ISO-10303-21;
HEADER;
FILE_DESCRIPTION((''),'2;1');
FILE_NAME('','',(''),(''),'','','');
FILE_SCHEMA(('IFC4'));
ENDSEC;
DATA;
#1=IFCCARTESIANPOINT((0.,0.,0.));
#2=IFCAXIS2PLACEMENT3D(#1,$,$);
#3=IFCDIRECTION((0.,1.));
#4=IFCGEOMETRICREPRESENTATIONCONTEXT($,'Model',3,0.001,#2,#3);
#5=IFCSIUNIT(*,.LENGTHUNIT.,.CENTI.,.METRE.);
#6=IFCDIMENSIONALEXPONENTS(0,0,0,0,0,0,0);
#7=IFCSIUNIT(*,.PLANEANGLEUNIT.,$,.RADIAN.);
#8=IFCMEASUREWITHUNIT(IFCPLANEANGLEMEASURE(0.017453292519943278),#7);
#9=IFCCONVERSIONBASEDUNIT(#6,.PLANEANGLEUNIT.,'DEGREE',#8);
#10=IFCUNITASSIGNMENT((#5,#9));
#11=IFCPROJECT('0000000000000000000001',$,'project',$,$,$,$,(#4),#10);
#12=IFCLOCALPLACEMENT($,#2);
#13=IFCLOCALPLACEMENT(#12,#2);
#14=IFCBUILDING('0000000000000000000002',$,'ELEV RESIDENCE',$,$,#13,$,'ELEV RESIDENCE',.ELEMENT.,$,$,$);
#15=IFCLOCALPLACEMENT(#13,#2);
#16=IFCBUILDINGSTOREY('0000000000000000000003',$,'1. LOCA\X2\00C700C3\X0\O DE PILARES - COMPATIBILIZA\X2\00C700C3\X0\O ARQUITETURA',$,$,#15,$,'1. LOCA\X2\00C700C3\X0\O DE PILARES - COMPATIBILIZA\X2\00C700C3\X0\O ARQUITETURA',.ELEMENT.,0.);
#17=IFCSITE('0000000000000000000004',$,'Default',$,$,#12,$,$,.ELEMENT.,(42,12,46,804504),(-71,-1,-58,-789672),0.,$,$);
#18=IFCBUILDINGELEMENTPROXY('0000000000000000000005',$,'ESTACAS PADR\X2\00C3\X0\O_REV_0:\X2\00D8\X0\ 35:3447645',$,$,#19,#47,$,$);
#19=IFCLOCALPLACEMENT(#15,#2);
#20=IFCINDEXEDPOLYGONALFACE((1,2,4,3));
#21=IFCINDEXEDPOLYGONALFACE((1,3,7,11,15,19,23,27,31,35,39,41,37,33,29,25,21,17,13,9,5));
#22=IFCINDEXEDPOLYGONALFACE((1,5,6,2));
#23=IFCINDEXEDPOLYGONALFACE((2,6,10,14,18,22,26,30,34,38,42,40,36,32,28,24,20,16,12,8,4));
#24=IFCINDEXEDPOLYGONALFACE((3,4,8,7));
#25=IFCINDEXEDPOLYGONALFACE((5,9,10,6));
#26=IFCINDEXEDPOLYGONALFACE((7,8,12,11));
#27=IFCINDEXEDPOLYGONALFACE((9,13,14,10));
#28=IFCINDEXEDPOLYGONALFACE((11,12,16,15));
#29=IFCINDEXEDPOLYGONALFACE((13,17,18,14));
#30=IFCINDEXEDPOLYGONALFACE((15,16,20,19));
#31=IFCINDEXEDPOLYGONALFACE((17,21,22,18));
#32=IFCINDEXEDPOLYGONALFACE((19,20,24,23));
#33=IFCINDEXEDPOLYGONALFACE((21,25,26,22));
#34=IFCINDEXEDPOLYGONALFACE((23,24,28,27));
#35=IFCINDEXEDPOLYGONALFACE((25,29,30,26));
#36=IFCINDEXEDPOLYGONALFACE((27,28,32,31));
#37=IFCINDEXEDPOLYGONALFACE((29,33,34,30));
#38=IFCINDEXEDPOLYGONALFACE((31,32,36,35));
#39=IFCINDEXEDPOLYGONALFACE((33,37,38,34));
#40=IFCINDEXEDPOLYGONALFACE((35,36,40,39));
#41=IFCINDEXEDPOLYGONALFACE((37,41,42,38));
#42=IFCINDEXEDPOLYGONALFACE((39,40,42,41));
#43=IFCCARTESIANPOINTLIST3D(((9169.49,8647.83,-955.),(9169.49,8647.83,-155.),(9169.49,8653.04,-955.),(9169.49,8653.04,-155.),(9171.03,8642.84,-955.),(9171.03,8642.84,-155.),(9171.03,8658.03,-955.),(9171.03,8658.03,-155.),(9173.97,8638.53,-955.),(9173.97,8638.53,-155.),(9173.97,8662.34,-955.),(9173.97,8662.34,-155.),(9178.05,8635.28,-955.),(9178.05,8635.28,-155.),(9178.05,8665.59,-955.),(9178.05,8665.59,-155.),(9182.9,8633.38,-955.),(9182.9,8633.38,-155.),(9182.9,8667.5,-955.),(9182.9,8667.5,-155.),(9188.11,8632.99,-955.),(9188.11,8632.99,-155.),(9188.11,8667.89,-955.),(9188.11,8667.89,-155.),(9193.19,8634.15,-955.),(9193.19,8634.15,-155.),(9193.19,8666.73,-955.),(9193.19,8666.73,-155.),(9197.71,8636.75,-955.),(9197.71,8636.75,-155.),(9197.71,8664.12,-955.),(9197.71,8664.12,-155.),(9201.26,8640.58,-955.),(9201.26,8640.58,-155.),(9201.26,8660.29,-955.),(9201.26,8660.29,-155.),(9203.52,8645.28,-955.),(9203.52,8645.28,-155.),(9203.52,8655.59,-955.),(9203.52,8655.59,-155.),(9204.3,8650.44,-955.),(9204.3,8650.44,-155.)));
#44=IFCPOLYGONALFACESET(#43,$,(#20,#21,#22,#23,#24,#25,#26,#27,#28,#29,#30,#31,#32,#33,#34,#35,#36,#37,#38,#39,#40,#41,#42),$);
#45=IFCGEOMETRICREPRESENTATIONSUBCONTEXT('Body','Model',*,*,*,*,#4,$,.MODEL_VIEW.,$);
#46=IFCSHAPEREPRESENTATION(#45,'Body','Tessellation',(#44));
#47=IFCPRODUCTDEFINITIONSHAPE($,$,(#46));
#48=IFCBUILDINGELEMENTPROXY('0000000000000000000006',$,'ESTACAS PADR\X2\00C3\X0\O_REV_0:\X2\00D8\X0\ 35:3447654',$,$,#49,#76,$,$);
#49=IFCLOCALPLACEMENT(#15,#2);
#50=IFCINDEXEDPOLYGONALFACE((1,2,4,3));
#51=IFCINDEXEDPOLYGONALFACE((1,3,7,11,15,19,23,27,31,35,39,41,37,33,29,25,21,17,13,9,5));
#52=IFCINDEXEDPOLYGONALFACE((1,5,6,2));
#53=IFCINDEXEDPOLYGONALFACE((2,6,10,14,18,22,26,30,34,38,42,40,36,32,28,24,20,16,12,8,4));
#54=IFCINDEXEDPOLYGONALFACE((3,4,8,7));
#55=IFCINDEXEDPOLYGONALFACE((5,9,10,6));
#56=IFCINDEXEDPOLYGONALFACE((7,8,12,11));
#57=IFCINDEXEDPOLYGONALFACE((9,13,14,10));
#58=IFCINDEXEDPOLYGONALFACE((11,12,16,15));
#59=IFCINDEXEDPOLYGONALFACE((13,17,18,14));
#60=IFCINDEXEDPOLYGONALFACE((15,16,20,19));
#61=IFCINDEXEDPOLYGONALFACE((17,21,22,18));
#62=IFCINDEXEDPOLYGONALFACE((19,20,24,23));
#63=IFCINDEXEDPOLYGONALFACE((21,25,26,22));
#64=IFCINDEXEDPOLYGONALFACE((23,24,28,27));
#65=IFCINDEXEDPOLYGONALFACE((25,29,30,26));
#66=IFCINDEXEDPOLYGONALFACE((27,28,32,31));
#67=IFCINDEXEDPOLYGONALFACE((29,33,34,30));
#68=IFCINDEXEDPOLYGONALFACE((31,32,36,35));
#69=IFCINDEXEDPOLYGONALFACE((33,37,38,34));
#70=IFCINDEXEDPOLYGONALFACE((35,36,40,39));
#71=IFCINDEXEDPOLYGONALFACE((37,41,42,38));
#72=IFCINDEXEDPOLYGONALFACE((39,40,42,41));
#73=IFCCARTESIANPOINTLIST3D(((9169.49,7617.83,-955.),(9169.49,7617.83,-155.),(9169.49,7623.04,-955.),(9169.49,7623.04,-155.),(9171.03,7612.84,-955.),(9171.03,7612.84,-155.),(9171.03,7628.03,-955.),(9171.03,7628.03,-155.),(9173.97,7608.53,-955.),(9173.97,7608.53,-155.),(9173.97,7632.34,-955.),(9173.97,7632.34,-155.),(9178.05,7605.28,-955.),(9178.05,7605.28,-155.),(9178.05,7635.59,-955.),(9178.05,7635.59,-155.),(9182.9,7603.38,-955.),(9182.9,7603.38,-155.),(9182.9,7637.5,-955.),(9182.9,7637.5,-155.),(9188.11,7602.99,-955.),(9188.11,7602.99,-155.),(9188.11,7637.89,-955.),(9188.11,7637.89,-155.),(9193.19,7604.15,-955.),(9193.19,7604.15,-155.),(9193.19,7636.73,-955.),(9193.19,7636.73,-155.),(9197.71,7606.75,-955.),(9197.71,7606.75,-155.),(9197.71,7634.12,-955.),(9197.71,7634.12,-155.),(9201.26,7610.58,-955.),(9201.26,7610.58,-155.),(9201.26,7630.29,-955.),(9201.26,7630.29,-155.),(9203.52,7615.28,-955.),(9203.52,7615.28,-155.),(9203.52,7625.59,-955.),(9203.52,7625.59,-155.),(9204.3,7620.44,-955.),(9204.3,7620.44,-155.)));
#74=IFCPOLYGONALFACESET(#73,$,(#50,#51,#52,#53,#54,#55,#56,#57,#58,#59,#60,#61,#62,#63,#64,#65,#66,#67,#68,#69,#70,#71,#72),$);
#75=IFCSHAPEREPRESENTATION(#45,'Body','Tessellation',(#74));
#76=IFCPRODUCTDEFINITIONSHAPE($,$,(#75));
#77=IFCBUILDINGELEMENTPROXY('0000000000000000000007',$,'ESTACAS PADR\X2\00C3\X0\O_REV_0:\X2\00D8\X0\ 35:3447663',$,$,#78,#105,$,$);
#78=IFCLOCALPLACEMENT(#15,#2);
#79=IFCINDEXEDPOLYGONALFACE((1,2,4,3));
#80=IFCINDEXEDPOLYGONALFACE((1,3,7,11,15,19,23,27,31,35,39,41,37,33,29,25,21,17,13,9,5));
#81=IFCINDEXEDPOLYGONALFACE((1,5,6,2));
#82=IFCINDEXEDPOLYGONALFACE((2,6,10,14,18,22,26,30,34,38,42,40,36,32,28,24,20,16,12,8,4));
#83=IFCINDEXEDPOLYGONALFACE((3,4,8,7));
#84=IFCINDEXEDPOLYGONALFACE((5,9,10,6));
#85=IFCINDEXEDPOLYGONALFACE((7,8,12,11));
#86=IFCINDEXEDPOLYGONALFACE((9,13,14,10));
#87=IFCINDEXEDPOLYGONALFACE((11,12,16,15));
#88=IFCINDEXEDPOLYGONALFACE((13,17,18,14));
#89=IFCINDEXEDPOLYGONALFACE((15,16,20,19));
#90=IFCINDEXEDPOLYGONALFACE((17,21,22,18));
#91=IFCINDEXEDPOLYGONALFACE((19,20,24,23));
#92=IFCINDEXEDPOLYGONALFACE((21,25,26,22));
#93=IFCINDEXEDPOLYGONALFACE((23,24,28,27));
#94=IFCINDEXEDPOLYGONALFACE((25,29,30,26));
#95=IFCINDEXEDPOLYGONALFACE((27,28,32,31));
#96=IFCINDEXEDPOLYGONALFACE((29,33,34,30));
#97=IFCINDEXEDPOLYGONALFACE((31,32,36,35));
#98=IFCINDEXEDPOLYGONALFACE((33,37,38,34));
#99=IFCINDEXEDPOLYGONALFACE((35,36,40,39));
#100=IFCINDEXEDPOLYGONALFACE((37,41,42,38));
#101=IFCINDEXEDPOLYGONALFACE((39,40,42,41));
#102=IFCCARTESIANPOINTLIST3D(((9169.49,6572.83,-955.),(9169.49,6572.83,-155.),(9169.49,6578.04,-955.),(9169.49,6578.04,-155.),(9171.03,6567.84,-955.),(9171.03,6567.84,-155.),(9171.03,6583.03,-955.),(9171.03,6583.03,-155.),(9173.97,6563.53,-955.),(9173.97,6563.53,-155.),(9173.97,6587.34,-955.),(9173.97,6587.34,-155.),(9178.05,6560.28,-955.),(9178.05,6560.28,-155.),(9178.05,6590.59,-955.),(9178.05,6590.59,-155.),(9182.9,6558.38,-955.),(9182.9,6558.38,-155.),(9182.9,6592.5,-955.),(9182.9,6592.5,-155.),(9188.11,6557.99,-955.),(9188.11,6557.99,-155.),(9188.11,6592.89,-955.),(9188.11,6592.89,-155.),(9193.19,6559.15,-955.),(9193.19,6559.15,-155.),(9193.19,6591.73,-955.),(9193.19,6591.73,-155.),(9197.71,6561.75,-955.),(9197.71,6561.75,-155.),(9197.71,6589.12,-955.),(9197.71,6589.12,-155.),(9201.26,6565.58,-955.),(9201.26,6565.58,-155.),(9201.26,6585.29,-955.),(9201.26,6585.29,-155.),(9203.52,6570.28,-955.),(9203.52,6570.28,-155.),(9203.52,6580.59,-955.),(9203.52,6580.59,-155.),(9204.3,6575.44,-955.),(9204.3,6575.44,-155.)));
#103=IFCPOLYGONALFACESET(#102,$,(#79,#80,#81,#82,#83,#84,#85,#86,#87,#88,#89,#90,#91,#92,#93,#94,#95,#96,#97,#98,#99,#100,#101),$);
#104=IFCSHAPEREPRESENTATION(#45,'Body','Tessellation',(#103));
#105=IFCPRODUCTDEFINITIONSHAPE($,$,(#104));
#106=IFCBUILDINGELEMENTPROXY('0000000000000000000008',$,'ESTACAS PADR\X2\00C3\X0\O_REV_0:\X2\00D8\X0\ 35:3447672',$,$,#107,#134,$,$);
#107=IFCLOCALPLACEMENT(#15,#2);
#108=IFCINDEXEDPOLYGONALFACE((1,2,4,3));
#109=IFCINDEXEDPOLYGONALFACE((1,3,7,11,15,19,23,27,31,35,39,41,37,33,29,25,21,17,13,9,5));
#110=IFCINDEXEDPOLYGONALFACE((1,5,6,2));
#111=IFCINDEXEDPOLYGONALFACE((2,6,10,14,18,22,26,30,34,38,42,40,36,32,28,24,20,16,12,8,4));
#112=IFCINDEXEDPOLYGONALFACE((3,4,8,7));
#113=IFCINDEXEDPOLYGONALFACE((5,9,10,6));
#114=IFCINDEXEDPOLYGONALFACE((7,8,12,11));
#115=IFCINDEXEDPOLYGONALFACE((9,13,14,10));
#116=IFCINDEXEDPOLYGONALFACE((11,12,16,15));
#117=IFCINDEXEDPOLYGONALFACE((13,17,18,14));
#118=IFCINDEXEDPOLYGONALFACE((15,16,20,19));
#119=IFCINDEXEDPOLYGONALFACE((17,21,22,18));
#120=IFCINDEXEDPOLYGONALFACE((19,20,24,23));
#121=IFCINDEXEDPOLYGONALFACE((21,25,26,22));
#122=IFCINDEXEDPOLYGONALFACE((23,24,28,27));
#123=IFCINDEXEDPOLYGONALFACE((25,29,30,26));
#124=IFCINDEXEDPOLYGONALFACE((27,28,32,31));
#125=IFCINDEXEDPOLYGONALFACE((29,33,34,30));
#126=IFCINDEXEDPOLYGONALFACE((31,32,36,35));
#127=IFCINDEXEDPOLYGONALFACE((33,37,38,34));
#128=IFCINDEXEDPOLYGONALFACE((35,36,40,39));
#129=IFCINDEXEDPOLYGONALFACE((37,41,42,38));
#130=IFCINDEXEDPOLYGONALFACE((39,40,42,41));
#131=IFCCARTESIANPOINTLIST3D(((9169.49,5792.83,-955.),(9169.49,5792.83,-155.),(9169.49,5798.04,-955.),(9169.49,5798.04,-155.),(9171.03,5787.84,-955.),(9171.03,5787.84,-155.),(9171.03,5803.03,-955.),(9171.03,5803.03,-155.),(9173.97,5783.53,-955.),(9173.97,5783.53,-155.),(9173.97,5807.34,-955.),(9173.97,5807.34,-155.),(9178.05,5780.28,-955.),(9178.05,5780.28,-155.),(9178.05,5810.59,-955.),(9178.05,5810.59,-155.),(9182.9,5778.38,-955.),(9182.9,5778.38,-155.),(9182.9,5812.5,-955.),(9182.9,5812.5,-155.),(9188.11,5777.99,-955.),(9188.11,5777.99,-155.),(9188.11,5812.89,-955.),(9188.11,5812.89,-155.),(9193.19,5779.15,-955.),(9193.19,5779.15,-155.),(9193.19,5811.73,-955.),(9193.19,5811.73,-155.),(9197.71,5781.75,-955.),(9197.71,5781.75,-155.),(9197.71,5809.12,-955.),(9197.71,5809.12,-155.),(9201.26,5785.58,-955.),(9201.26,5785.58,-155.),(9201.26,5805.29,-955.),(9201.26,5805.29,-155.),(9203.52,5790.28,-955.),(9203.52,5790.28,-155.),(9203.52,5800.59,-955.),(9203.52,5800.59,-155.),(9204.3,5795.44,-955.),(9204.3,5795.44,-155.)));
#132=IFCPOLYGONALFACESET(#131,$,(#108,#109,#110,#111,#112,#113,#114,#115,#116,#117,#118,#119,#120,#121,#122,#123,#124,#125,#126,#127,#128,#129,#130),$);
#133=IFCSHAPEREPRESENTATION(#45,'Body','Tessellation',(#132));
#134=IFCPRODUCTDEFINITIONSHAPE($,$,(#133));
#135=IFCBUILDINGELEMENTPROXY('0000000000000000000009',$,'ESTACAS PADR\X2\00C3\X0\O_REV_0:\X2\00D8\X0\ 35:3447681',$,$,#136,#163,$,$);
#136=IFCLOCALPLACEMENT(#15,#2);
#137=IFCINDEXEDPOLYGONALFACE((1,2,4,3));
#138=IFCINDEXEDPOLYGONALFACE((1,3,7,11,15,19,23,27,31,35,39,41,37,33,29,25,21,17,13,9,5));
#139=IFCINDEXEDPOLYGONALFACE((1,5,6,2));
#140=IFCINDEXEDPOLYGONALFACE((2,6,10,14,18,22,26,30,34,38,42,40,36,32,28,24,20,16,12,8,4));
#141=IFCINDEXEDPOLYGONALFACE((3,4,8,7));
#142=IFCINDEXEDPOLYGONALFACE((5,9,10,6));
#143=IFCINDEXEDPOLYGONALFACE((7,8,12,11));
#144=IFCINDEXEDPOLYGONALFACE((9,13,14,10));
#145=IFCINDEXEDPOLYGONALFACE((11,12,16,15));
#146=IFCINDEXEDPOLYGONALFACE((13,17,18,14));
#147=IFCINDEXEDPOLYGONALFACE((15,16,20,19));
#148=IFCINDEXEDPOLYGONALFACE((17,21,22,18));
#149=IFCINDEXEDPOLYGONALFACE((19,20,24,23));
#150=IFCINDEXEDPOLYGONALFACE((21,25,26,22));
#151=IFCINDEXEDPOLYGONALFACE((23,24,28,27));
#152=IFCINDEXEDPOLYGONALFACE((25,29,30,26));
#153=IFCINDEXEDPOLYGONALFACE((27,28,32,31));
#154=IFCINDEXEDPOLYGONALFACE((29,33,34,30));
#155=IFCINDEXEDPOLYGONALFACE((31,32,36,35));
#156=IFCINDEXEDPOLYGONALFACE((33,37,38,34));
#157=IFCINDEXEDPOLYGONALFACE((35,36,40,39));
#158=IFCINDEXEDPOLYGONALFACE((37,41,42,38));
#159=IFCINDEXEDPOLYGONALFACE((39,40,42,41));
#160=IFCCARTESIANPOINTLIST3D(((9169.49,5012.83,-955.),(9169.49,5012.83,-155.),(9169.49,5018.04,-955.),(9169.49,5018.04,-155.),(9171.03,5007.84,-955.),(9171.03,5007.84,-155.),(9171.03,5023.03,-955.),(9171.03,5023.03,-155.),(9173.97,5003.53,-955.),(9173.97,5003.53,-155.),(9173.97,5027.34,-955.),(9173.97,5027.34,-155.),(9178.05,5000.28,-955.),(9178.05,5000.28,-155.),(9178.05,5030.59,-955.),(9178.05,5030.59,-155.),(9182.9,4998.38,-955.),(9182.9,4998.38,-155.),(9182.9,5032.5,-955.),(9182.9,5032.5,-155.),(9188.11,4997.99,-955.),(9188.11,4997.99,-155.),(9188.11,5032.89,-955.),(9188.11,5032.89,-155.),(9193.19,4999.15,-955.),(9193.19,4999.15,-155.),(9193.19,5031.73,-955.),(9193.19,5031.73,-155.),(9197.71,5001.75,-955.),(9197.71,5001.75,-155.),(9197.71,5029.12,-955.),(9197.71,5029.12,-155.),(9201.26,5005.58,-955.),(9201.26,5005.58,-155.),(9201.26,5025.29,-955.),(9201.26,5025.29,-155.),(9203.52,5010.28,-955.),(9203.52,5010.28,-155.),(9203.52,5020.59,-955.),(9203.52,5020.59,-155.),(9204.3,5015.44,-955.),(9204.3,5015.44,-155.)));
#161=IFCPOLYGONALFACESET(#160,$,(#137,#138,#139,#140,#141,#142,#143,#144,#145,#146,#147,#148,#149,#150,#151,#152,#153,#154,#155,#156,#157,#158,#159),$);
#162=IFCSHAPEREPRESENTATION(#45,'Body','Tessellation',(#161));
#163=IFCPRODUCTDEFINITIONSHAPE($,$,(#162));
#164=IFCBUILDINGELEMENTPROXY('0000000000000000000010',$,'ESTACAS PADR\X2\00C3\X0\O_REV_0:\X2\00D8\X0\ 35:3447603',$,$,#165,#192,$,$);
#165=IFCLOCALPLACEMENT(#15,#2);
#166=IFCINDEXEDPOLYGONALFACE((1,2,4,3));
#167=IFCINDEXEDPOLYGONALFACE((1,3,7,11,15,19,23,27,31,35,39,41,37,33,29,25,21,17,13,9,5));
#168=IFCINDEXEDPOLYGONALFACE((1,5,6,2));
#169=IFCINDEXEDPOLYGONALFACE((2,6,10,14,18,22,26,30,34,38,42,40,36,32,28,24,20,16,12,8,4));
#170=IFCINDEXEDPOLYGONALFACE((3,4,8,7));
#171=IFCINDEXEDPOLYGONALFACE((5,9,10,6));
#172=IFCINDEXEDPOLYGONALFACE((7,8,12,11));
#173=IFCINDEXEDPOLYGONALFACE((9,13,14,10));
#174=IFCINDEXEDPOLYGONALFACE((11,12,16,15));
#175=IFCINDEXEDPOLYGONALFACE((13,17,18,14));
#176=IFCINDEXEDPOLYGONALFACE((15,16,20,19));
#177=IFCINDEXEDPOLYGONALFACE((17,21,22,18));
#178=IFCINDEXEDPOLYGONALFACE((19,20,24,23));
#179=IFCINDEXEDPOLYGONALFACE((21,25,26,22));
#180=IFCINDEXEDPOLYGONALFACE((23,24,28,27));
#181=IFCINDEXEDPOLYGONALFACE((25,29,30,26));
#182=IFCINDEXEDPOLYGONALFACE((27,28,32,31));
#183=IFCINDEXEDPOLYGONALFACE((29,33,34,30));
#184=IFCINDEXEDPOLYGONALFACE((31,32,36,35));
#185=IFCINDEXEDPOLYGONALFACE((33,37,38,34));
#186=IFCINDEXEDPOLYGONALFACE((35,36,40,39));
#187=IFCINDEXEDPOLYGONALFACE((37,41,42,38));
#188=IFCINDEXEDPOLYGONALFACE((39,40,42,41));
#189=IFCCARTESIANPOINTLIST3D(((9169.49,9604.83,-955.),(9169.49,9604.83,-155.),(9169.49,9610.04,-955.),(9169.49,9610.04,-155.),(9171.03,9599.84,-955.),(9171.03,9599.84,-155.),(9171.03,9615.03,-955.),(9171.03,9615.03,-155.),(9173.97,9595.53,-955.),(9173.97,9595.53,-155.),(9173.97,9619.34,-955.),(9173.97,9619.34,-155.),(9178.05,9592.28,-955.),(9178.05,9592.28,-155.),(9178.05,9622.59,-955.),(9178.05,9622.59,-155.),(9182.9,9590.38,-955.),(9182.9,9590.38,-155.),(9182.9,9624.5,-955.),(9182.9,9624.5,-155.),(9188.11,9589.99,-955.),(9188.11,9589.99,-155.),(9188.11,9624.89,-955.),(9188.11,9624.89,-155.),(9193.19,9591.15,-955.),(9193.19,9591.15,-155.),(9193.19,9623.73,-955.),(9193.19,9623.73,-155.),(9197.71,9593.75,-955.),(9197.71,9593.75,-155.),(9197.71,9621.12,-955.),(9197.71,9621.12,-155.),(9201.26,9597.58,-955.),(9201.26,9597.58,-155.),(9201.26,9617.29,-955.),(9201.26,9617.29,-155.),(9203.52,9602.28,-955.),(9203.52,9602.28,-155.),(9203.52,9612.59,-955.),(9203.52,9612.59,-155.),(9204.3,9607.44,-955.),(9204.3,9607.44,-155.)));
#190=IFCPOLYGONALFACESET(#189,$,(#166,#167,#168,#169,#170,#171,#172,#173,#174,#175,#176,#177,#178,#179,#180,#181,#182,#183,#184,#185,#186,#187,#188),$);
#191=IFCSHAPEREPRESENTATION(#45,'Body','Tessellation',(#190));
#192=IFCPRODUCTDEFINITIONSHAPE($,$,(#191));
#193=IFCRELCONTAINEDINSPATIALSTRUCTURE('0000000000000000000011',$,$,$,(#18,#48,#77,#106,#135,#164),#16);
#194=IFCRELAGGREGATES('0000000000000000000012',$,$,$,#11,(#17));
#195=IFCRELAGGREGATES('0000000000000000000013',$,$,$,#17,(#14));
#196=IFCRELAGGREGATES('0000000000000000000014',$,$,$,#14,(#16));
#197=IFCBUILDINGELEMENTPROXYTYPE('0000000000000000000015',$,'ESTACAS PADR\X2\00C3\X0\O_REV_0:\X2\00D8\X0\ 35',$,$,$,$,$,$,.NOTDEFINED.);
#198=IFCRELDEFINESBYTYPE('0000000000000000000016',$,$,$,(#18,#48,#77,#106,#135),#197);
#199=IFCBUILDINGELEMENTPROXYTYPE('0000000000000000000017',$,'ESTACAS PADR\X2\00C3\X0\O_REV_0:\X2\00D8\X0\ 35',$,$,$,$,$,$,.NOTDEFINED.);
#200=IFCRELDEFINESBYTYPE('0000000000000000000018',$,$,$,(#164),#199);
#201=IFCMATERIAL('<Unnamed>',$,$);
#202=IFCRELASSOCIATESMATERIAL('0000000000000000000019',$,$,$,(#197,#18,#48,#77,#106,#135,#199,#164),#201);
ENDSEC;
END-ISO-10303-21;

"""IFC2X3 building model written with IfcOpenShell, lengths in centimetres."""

from ifc_helpers import new_model, entity, si_unit, converted_unit, direction, frame, frame_2d, origin, place, context, subcontext, project, spatial, circle, extrude, source, transform, mapped, material, type_object, type_shapes, element, save


model = new_model("IFC2X3")

# Units and contexts
model_context = context("Model", 3, precision=0.001, world=origin(), true_north=direction((0.0, 1.0)))
body_context = subcontext(model_context, "Body", "Model", "MODEL_VIEW")
ifc_project = project(units=[si_unit("LENGTHUNIT", "METRE", prefix="CENTI"), converted_unit("PLANEANGLEUNIT", "DEGREE", entity("IfcPlaneAngleMeasure", 0.017453292519943278), si_unit("PLANEANGLEUNIT", "RADIAN"), dimensions=[0, 0, 0, 0, 0, 0, 0])], contexts=[model_context])

# Site, building, storey
site_placement = place(None, origin())
site = spatial("IfcSite", under=ifc_project, at=site_placement, Name="Default", CompositionType="ELEMENT", RefLatitude=(42, 12, 46, 804504), RefLongitude=(-71, -1, -58, -789672), RefElevation=0.0)
building_placement = place(site_placement, origin())
building = spatial("IfcBuilding", under=site, at=building_placement, Name="ELEV RESIDENCE", LongName="ELEV RESIDENCE", CompositionType="ELEMENT")
storey_placement = place(building_placement, origin())
storey = spatial("IfcBuildingStorey", under=building, at=storey_placement, Name="1. LOCAÇÃO DE PILARES - COMPATIBILIZAÇÃO ARQUITETURA", LongName="1. LOCAÇÃO DE PILARES - COMPATIBILIZAÇÃO ARQUITETURA", CompositionType="ELEMENT", Elevation=0.0)

# Building element proxies
ifc_material_1 = material(Name="<Unnamed>")
building_element_proxy_type_1 = type_object("IfcBuildingElementProxyType", Name="ESTACAS PADRÃO_REV_0:Ø 35", PredefinedType="NOTDEFINED", material=ifc_material_1)
shared_shape_1 = source(origin(), body_context, "Body", "SweptSolid", [
    extrude(circle(Radius=17.5, at=frame_2d((0.0, 0.0), x_axis=(1.0, 0.0))), frame((0.0, 0.0, -955.0)), (0.0, 0.0, 1.0), 800.0),
])
type_shapes(building_element_proxy_type_1, [shared_shape_1])
for number, where, name in (
    (1, (9186.8, 8650.44, 0.0), "ESTACAS PADRÃO_REV_0:Ø 35:3447645"),
    (2, (9186.8, 7620.44, 0.0), "ESTACAS PADRÃO_REV_0:Ø 35:3447654"),
    (3, (9186.8, 6575.44, 0.0), "ESTACAS PADRÃO_REV_0:Ø 35:3447663"),
    (4, (9186.8, 5795.44, 0.0), "ESTACAS PADRÃO_REV_0:Ø 35:3447672"),
    (5, (9186.8, 5015.44, 0.0), "ESTACAS PADRÃO_REV_0:Ø 35:3447681"),
):
    element("IfcBuildingElementProxy", number, at=place(storey_placement, frame(where)), inside=storey, type_object=building_element_proxy_type_1, material=ifc_material_1, Name=name, context=body_context, shape_type="MappedRepresentation", body=[
        mapped(shared_shape_1, transform((0.0, 0.0, 0.0), scale=1.0)),
    ])
building_element_proxy_type_2 = type_object("IfcBuildingElementProxyType", Name="ESTACAS PADRÃO_REV_0:Ø 35", PredefinedType="NOTDEFINED", material=ifc_material_1)
shared_shape_2 = source(origin(), body_context, "Body", "SweptSolid", [
    extrude(circle(Radius=17.5, at=frame_2d((0.0, 0.0), x_axis=(1.0, 0.0))), frame((0.0, 0.0, -955.0)), (0.0, 0.0, 1.0), 800.0),
])
type_shapes(building_element_proxy_type_2, [shared_shape_2])
for number, where, name in (
    (6, (9186.8, 9607.44, 0.0), "ESTACAS PADRÃO_REV_0:Ø 35:3447603"),
):
    element("IfcBuildingElementProxy", number, at=place(storey_placement, frame(where)), inside=storey, type_object=building_element_proxy_type_2, material=ifc_material_1, Name=name, context=body_context, shape_type="MappedRepresentation", body=[
        mapped(shared_shape_2, transform((0.0, 0.0, 0.0), scale=1.0)),
    ])

save(model, "model.ifc")
